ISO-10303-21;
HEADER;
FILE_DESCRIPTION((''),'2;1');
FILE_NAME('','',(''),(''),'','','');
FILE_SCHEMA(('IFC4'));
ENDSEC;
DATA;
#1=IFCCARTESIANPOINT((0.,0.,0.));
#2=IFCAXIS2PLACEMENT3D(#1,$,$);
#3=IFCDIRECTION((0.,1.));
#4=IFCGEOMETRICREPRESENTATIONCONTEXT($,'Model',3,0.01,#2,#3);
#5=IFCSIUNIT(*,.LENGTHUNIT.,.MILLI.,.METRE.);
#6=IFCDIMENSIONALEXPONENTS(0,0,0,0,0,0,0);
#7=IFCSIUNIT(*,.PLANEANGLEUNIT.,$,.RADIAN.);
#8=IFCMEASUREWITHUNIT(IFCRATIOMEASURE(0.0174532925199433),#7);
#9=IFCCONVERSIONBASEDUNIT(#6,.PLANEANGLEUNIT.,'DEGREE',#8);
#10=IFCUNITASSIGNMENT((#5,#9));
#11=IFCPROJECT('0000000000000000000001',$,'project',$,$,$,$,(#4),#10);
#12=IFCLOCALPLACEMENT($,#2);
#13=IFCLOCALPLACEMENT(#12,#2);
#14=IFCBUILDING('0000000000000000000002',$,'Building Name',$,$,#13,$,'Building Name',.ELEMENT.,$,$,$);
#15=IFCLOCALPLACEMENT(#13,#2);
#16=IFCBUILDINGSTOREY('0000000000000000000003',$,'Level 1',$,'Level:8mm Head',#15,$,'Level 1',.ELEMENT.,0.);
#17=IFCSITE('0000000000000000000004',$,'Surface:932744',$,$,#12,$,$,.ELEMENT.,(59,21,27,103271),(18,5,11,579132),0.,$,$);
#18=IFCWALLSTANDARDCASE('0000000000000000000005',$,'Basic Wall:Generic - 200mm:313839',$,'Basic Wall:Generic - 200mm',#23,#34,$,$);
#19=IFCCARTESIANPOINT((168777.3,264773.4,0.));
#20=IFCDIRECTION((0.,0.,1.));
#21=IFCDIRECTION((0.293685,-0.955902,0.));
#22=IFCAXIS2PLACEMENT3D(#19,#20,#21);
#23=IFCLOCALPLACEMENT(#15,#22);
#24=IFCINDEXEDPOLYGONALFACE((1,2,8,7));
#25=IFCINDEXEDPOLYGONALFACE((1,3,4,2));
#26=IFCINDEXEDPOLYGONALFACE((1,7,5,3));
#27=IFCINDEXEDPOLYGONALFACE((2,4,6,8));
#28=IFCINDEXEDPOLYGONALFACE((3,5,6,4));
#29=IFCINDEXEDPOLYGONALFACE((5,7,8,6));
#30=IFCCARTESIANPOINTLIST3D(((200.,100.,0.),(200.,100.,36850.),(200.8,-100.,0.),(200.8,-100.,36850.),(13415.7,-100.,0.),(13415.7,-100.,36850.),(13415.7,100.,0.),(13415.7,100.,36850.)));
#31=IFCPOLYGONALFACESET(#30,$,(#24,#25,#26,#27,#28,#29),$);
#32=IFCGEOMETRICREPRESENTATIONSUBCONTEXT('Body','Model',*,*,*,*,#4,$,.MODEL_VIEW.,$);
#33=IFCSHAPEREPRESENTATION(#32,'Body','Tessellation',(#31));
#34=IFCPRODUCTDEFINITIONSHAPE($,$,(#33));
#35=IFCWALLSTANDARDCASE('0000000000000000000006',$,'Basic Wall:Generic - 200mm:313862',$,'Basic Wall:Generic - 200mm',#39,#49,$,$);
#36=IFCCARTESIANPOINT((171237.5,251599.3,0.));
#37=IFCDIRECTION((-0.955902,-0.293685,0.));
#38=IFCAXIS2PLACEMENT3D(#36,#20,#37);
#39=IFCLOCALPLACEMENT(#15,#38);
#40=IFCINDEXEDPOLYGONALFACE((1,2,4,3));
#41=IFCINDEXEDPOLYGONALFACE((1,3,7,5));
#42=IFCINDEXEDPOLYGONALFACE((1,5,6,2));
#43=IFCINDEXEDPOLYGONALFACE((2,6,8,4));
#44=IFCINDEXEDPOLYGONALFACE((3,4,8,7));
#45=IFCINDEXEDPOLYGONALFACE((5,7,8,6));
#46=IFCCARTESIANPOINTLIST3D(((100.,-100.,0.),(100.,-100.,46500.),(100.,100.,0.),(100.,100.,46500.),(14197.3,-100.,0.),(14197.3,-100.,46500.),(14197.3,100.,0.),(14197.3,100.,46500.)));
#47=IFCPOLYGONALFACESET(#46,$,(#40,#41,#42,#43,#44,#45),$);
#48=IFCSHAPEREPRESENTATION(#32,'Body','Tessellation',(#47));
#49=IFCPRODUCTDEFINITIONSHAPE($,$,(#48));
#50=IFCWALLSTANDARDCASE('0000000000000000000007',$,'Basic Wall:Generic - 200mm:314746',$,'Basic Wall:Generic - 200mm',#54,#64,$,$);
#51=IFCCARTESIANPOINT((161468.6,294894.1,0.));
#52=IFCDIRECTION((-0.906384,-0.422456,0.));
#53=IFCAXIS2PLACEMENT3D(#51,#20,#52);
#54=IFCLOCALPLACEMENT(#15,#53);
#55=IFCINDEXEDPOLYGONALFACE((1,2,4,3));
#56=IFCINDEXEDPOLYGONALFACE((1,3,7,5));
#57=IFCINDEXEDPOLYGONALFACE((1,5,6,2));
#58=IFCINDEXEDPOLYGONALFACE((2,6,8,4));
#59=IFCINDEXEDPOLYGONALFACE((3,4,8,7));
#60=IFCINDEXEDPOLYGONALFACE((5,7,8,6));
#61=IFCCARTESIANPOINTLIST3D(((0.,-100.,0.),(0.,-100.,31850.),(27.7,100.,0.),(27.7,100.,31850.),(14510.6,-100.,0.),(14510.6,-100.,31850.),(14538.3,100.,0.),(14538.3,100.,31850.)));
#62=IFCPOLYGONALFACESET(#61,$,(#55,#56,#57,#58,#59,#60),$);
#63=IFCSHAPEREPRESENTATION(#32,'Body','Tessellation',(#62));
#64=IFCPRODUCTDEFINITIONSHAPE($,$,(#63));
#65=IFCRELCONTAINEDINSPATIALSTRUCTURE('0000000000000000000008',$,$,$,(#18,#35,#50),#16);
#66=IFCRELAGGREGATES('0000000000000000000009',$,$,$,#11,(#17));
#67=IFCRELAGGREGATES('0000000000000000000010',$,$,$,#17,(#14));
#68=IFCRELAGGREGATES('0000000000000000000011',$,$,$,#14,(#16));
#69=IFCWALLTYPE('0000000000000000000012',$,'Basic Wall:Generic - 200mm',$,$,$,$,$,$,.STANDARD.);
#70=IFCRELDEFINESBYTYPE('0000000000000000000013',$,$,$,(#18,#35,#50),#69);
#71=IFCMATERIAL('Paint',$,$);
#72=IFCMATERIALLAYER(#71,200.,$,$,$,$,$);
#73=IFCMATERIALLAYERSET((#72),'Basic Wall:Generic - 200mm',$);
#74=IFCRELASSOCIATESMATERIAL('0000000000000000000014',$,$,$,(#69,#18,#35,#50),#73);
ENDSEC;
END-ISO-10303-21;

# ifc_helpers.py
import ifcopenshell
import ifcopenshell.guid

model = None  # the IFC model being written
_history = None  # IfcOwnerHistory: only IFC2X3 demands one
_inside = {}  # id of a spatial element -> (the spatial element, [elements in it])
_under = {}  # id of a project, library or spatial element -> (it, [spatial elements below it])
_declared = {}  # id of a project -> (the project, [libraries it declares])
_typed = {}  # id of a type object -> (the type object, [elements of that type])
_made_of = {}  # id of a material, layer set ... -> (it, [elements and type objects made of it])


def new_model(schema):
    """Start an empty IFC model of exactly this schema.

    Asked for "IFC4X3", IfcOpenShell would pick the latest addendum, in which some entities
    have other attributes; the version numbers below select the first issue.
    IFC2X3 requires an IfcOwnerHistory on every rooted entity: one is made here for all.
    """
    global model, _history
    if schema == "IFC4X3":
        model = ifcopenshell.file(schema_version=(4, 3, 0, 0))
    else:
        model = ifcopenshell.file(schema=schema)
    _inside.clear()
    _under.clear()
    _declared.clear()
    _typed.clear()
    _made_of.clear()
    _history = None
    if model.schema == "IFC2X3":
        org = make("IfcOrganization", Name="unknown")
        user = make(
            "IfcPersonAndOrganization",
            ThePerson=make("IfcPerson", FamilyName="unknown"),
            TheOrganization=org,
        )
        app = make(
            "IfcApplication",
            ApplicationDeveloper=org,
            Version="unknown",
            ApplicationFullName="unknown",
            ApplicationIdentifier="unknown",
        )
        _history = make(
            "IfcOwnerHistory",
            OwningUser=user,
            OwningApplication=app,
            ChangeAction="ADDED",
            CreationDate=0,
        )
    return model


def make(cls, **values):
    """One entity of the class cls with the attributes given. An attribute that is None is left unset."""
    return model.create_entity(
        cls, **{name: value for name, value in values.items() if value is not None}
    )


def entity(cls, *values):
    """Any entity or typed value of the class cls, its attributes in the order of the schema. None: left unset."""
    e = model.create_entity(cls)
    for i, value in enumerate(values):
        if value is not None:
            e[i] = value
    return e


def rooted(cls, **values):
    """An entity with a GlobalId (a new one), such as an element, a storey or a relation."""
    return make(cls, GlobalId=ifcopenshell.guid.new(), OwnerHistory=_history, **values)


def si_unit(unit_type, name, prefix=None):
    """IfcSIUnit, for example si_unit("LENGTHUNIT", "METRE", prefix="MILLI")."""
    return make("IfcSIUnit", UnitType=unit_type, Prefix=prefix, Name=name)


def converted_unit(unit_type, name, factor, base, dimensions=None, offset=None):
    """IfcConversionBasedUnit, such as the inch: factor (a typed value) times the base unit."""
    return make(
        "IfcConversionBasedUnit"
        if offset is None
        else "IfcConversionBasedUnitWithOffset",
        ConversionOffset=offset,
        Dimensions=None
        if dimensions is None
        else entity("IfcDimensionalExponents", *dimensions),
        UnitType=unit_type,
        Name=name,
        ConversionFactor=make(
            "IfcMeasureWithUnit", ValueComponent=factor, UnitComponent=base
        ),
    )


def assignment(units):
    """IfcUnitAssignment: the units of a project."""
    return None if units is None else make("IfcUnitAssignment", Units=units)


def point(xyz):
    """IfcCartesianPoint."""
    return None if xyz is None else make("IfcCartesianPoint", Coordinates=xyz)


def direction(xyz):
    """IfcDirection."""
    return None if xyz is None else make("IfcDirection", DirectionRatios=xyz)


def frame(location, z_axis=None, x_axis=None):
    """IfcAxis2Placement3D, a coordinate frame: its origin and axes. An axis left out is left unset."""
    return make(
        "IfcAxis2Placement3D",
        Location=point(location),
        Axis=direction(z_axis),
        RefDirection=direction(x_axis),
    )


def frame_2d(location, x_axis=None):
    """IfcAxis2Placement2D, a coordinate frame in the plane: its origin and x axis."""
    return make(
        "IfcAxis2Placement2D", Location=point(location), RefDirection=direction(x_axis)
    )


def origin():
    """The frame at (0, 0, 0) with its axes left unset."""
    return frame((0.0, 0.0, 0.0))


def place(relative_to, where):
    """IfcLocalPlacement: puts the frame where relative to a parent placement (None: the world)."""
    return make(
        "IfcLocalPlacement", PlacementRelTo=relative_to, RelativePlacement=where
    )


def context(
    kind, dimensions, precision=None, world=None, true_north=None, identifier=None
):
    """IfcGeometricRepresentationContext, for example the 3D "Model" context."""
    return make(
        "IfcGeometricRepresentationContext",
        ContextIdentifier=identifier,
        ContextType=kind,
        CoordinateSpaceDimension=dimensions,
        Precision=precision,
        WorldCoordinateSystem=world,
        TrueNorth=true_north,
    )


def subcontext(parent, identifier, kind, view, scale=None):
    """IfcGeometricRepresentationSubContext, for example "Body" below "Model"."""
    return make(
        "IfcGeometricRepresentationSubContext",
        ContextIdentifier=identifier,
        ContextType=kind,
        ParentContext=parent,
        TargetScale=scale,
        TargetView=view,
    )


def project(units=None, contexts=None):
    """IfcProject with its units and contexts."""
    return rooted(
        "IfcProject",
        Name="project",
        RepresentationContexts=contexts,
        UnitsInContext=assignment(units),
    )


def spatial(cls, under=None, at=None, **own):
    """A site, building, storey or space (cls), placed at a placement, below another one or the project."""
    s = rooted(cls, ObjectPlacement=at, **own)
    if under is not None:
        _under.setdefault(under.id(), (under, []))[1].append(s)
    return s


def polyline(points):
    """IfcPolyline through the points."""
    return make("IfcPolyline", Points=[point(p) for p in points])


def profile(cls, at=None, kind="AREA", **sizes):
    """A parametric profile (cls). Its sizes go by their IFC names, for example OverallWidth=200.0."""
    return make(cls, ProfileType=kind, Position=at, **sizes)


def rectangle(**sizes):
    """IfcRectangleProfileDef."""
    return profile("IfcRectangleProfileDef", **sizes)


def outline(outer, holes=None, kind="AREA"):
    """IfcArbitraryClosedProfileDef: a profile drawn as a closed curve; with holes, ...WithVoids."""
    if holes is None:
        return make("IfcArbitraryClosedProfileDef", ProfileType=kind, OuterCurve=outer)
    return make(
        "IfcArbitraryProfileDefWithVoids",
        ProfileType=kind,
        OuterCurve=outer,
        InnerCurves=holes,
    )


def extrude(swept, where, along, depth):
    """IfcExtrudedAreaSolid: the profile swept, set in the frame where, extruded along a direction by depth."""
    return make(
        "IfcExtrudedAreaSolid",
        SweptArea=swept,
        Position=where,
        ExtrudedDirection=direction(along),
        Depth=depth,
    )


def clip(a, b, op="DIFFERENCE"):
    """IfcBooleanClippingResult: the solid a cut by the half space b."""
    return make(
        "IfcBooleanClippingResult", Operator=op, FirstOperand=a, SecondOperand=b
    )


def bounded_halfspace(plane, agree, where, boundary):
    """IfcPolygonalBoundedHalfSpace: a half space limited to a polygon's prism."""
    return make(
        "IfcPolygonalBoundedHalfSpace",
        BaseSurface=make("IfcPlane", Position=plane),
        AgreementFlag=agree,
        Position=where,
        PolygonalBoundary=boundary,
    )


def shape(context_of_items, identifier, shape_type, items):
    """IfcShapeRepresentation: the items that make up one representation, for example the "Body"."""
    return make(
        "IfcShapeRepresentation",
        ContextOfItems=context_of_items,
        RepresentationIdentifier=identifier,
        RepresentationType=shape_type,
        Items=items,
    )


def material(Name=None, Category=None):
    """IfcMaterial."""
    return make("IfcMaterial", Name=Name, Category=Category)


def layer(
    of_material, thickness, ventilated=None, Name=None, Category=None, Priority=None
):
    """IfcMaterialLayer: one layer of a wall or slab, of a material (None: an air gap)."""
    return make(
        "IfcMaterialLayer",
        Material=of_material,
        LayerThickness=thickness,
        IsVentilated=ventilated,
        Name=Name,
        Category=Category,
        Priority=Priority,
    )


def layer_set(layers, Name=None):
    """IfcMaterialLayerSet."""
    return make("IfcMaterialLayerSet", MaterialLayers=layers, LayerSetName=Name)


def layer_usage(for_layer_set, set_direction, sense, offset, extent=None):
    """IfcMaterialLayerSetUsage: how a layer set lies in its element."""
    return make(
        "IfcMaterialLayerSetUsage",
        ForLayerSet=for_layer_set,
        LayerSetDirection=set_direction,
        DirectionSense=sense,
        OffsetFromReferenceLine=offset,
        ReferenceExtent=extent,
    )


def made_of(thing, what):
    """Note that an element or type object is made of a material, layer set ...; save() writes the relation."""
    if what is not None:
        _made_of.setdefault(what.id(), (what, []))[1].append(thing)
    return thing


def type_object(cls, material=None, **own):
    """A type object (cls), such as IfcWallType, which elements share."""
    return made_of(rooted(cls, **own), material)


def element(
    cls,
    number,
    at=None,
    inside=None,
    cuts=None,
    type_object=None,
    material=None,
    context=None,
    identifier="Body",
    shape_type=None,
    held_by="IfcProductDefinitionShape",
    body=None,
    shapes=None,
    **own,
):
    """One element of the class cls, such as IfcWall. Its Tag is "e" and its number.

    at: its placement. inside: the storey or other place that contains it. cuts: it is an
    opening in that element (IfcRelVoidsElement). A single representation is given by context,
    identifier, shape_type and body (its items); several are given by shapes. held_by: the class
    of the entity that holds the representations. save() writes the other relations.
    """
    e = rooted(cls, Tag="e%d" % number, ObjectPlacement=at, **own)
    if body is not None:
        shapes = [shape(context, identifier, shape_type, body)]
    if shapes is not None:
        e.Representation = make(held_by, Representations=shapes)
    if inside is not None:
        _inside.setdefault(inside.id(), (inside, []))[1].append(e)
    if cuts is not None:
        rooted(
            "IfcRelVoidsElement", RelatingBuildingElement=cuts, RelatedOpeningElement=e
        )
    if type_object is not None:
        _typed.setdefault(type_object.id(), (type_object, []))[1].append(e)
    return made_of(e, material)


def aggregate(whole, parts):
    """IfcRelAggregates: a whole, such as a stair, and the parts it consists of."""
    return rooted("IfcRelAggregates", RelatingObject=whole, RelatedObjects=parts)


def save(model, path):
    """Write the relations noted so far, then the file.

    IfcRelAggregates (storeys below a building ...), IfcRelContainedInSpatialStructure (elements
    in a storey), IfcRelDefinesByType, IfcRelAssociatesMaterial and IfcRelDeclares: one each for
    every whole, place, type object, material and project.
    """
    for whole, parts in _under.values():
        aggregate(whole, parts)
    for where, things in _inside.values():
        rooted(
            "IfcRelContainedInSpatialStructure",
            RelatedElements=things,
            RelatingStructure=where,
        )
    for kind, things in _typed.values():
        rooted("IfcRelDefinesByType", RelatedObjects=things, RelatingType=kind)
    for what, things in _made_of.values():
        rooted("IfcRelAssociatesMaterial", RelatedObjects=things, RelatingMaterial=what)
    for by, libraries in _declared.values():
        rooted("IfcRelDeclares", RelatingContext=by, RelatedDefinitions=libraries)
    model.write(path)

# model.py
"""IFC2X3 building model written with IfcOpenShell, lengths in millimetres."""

from ifc_helpers import new_model, entity, si_unit, converted_unit, direction, frame, frame_2d, origin, place, context, subcontext, project, spatial, polyline, rectangle, outline, extrude, clip, bounded_halfspace, material, layer, layer_set, layer_usage, type_object, element, save


model = new_model("IFC2X3")

# Units and contexts
model_context = context("Model", 3, precision=0.01, world=origin(), true_north=direction((0.0, 1.0)))
body_context = subcontext(model_context, "Body", "Model", "MODEL_VIEW")
ifc_project = project(units=[si_unit("LENGTHUNIT", "METRE", prefix="MILLI"), converted_unit("PLANEANGLEUNIT", "DEGREE", entity("IfcRatioMeasure", 0.0174532925199433), si_unit("PLANEANGLEUNIT", "RADIAN"), dimensions=[0, 0, 0, 0, 0, 0, 0])], contexts=[model_context])

# Site, building, storey
site_placement = place(None, origin())
site = spatial("IfcSite", under=ifc_project, at=site_placement, Name="Surface:932744", CompositionType="ELEMENT", RefLatitude=(59, 21, 27, 103271), RefLongitude=(18, 5, 11, 579132), RefElevation=0.0)
building_placement = place(site_placement, origin())
building = spatial("IfcBuilding", under=site, at=building_placement, Name="Building Name", LongName="Building Name", CompositionType="ELEMENT")
storey_placement = place(building_placement, origin())
storey = spatial("IfcBuildingStorey", under=building, at=storey_placement, Name="Level 1", ObjectType="Level:8mm Head", LongName="Level 1", CompositionType="ELEMENT", Elevation=0.0)

# Walls
ifc_material_1 = material(Name="Paint")
ifc_layer_1 = layer(ifc_material_1, 200.0)
ifc_layer_set_1 = layer_set([ifc_layer_1], Name="Basic Wall:Generic - 200mm")
ifc_layer_usage_1 = layer_usage(ifc_layer_set_1, "AXIS2", "NEGATIVE", 100.0)
wall_type = type_object("IfcWallType", Name="Basic Wall:Generic - 200mm", PredefinedType="STANDARD", material=ifc_layer_set_1)
wall_1_placement = place(storey_placement, frame((168777.3, 264773.4, 0.0), z_axis=(0.0, 0.0, 1.0), x_axis=(0.293685, -0.955902, 0.0)))
element("IfcWallStandardCase", 1, at=wall_1_placement, inside=storey, type_object=wall_type, material=ifc_layer_usage_1, Name="Basic Wall:Generic - 200mm:313839", ObjectType="Basic Wall:Generic - 200mm", context=body_context, shape_type="Clipping", body=[
    clip(extrude(outline(polyline([(13415.7, -100.0), (13415.7, 100.0), (200.0, 100.0), (200.8, -100.0), (13215.7, -100.0), (13415.7, -100.0)])), origin(), (0.0, 0.0, 1.0), 46500.0), bounded_halfspace(frame((13215.7, -100.0, 36850.0), z_axis=(0.0, 0.0, -1.0), x_axis=(-1.0, 0.0, 0.0)), True, frame((13215.7, -100.0, 36850.0), z_axis=(0.0, 0.0, -1.0), x_axis=(-1.0, 0.0, 0.0)), polyline([(0.0, 0.0), (13014.9, 0.0), (13015.7, 200.0), (-200.0, 200.0), (-200.0, 0.0), (0.0, 0.0)]))),
])
ifc_layer_usage_2 = layer_usage(ifc_layer_set_1, "AXIS2", "NEGATIVE", 100.0)
wall_2_placement = place(storey_placement, frame((171237.5, 251599.3, 0.0), z_axis=(0.0, 0.0, 1.0), x_axis=(-0.955902, -0.293685, 0.0)))
element("IfcWallStandardCase", 2, at=wall_2_placement, inside=storey, type_object=wall_type, material=ifc_layer_usage_2, Name="Basic Wall:Generic - 200mm:313862", ObjectType="Basic Wall:Generic - 200mm", context=body_context, shape_type="SweptSolid", body=[
    extrude(rectangle(XDim=14097.3, YDim=200.0, at=frame_2d((7148.7, 0.0), x_axis=(-1.0, 0.0))), origin(), (0.0, 0.0, 1.0), 46500.0),
])
ifc_layer_usage_3 = layer_usage(ifc_layer_set_1, "AXIS2", "NEGATIVE", 100.0)
wall_3_placement = place(storey_placement, frame((161468.6, 294894.1, 0.0), z_axis=(0.0, 0.0, 1.0), x_axis=(-0.906384, -0.422456, 0.0)))
element("IfcWallStandardCase", 3, at=wall_3_placement, inside=storey, type_object=wall_type, material=ifc_layer_usage_3, Name="Basic Wall:Generic - 200mm:314746", ObjectType="Basic Wall:Generic - 200mm", context=body_context, shape_type="Clipping", body=[
    clip(extrude(outline(polyline([(14510.6, -100.0), (14538.3, 100.0), (27.7, 100.0), (0.0, -100.0), (14510.6, -100.0)])), origin(), (0.0, 0.0, 1.0), 31850.0), bounded_halfspace(frame((0.0, -100.0, 31850.0), z_axis=(0.0, 0.0, -1.0), x_axis=(0.137399, 0.990516, 0.0)), True, frame((0.0, -100.0, 31850.0), z_axis=(0.0, 0.0, -1.0), x_axis=(0.137399, 0.990516, 0.0)), polyline([(0.0, 0.0), (201.9, 0.0), (2195.6, 14372.9), (1993.7, 14372.9), (0.0, 0.0)]))),
])

save(model, "model.ifc")
